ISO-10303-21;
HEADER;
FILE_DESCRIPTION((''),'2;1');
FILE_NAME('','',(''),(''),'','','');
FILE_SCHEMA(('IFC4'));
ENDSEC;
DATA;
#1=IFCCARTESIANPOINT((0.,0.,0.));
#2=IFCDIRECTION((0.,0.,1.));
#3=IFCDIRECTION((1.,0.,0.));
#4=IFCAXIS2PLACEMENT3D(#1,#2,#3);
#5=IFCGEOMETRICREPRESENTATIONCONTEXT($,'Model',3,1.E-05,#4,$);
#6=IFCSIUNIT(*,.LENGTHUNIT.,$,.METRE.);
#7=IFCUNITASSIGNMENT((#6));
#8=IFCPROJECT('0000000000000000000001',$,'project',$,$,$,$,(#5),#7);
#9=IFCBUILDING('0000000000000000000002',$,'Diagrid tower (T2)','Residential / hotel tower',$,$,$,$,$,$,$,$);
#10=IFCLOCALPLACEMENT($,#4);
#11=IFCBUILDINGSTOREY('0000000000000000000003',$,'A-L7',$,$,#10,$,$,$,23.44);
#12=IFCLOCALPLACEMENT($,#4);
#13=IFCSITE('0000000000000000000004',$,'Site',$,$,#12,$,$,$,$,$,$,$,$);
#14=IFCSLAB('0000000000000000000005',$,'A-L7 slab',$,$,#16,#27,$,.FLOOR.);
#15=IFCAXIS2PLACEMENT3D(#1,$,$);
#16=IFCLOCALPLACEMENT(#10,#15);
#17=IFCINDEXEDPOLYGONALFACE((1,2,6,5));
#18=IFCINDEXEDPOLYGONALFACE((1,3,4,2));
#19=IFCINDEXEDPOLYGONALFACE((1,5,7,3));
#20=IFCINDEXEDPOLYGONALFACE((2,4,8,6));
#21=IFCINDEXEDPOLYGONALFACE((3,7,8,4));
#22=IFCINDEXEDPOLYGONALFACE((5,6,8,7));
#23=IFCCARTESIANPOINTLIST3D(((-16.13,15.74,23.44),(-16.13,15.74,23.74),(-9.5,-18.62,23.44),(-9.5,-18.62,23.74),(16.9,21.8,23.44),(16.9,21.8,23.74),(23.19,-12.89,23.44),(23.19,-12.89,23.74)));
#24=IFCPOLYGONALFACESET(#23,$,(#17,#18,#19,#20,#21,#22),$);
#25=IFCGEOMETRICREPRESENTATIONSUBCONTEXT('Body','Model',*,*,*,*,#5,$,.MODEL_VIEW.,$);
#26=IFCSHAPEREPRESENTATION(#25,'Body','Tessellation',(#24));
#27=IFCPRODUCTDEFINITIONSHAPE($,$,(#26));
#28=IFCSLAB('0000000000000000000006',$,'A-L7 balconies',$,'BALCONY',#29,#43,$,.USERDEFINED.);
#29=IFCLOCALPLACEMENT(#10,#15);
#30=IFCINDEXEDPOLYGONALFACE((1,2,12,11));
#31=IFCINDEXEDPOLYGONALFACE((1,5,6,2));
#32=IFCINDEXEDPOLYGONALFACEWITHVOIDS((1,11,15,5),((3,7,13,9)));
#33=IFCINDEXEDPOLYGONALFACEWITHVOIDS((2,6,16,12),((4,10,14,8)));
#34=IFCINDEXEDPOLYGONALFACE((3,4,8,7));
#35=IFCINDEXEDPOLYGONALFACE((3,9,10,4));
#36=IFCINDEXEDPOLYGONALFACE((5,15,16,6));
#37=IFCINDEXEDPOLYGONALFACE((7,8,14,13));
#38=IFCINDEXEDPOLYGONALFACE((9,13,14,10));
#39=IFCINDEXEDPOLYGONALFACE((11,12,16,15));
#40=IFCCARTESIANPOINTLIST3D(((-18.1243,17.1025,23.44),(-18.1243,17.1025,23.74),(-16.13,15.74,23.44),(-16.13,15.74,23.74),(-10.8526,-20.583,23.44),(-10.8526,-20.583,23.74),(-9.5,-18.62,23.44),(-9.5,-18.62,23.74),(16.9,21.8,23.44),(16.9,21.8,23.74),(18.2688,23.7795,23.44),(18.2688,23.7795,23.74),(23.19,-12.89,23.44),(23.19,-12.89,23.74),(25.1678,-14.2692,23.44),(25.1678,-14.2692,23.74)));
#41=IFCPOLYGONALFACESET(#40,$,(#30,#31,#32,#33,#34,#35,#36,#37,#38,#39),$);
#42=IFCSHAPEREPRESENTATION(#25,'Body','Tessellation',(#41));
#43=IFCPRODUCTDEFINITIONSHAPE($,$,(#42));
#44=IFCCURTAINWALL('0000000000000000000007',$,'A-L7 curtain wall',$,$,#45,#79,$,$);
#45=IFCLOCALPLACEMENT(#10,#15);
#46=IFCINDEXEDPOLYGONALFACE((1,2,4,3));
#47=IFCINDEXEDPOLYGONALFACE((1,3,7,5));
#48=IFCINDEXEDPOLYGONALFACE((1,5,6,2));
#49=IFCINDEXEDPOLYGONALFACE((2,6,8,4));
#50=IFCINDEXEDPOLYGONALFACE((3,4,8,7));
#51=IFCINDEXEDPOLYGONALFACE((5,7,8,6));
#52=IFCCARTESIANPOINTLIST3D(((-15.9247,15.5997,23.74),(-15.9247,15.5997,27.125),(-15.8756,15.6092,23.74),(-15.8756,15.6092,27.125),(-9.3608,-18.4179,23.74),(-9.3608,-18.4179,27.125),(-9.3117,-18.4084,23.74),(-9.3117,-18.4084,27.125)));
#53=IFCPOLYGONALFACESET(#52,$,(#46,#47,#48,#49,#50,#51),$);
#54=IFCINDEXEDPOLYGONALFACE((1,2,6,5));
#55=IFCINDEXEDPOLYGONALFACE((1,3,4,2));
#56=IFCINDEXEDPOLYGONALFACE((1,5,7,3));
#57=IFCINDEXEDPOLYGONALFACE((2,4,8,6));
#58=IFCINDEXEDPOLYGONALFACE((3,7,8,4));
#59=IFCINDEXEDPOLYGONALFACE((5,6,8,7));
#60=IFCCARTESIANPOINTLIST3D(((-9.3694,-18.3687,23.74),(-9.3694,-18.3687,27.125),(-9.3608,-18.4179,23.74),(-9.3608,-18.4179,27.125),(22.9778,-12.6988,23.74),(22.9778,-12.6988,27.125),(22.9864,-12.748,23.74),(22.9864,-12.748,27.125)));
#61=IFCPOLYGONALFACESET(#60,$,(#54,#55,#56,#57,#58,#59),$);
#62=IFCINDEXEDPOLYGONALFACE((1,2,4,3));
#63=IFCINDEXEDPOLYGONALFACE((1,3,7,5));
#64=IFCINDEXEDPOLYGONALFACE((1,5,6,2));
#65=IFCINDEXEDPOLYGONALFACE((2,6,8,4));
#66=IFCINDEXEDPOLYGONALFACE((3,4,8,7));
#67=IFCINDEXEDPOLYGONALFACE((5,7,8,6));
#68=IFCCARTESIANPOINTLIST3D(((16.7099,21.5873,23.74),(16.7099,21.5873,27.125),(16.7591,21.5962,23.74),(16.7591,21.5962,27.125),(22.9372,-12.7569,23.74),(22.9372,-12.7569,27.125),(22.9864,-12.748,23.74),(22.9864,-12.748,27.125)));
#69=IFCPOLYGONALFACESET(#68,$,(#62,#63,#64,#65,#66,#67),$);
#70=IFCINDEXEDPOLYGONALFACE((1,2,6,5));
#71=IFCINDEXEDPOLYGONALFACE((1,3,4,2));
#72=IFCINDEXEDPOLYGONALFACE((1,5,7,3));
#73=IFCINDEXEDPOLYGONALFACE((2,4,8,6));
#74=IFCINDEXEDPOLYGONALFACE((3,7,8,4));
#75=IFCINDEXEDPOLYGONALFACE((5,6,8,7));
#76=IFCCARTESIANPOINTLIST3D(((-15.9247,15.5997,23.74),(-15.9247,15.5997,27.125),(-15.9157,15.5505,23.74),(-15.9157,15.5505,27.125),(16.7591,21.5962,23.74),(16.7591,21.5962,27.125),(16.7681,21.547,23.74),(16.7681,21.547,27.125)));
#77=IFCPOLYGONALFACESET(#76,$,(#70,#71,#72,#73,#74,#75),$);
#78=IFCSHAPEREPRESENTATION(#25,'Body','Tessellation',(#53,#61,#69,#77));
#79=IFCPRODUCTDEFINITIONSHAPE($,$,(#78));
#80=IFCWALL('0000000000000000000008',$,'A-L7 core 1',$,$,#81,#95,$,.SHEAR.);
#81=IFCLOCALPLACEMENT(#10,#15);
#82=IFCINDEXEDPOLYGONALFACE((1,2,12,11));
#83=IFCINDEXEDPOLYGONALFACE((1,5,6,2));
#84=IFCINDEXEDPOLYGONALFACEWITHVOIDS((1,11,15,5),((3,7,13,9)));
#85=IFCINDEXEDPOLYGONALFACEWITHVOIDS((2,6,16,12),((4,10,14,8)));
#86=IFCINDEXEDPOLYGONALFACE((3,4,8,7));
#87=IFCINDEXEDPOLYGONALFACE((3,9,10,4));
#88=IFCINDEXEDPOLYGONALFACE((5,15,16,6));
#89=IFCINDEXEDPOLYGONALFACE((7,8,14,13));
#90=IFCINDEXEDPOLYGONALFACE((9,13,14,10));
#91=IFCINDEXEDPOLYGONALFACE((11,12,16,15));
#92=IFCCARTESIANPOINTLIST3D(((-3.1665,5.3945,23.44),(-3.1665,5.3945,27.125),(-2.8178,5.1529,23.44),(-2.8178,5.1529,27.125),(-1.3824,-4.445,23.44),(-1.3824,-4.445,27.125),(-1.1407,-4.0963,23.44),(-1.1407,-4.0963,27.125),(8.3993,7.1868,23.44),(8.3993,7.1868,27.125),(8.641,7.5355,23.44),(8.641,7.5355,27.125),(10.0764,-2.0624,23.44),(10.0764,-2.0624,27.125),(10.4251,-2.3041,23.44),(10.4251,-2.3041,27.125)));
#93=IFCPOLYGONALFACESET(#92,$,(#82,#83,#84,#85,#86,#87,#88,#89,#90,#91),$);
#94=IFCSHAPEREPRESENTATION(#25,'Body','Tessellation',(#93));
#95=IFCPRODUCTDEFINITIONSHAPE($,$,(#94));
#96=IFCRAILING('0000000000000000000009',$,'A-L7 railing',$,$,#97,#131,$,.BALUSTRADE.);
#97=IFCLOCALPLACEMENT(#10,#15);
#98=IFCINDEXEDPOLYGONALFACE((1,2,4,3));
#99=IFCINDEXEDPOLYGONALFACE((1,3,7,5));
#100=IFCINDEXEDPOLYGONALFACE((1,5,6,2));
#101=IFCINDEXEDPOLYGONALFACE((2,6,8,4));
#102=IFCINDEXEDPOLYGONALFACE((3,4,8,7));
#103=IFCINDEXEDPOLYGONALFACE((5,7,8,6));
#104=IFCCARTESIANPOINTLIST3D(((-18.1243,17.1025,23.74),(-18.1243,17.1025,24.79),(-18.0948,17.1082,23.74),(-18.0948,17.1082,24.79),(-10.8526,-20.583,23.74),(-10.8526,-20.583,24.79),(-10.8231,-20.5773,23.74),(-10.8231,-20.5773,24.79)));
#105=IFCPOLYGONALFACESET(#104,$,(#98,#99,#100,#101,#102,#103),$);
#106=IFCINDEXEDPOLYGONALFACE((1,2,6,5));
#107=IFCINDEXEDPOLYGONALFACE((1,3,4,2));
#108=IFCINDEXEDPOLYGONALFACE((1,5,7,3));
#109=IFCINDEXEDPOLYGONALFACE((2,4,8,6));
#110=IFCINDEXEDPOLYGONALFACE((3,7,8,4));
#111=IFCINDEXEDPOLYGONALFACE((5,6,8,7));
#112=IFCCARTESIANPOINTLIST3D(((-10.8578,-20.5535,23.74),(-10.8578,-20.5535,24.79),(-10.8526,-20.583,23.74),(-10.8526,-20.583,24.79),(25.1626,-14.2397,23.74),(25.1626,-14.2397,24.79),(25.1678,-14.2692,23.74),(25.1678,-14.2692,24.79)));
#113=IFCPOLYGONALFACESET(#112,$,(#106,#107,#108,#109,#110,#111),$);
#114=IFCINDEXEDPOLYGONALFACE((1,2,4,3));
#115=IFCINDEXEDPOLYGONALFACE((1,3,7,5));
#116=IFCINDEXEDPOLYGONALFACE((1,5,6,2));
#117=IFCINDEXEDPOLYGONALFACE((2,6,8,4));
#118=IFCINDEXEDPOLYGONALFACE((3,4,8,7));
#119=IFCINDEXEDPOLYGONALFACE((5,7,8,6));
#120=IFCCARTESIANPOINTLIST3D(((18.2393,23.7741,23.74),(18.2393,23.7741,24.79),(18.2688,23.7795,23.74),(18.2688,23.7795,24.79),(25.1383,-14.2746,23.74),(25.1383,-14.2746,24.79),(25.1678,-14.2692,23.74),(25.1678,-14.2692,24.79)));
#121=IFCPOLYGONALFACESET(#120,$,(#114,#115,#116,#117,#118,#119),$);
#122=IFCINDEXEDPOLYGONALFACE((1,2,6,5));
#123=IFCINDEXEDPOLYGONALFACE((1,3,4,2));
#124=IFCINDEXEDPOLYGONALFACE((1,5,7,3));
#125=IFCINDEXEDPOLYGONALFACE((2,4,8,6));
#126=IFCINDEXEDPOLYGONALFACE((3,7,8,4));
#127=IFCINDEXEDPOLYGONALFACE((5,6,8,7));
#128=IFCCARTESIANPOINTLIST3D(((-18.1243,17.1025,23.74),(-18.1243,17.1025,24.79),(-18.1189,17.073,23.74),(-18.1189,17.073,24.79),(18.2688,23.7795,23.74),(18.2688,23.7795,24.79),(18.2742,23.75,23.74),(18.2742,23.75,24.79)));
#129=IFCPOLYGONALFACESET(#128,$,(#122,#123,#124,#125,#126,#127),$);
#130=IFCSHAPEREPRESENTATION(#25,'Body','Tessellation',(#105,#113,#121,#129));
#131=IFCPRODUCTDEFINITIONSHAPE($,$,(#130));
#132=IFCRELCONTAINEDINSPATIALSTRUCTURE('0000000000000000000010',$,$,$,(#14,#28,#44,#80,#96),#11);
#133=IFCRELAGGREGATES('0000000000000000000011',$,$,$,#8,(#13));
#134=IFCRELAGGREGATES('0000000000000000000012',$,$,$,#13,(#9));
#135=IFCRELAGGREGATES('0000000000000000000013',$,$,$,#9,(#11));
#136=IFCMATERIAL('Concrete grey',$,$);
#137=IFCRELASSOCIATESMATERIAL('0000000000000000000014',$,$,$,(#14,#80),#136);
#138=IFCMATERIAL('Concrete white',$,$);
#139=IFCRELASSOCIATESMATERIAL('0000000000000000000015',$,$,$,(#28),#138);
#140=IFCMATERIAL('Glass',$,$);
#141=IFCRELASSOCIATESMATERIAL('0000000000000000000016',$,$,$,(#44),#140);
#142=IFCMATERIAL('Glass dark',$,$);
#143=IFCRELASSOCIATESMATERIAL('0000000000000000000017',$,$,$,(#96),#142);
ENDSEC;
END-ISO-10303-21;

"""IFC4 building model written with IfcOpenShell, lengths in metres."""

from ifc_helpers import new_model, si_unit, frame, origin_with_axes, place, context, subcontext, project, spatial, polyline, outline, extrude, material, element, save


model = new_model("IFC4")

# Units and contexts
model_context = context("Model", 3, precision=1e-05, world=origin_with_axes())
body_context = subcontext(model_context, "Body", "Model", "MODEL_VIEW")
ifc_project = project(units=[si_unit("LENGTHUNIT", "METRE")], contexts=[model_context])

# Site, building, storey
site_placement = place(None, origin_with_axes())
site = spatial("IfcSite", under=ifc_project, at=site_placement, Name="Site")
building = spatial("IfcBuilding", under=site, Name="Diagrid tower (T2)", Description="Residential / hotel tower")
storey_placement = place(None, origin_with_axes())
storey = spatial("IfcBuildingStorey", under=building, at=storey_placement, Name="A-L7", Elevation=23.44)

# Slabs
ifc_material_1 = material(Name="Concrete grey")
slab_1_placement = place(storey_placement, origin_with_axes())
element("IfcSlab", 1, at=slab_1_placement, inside=storey, material=ifc_material_1, Name="A-L7 slab", PredefinedType="FLOOR", context=body_context, shape_type="SweptSolid", body=[
    extrude(outline(polyline([(-16.13, 15.74), (-9.5, -18.62), (23.19, -12.89), (16.9, 21.8), (-16.13, 15.74)])), frame((0.0, 0.0, 23.44), z_axis=(0.0, 0.0, 1.0), x_axis=(1.0, 0.0, 0.0)), (0.0, 0.0, 1.0), 0.3),
])
ifc_material_2 = material(Name="Concrete white")
slab_2_placement = place(storey_placement, origin_with_axes())
element("IfcSlab", 2, at=slab_2_placement, inside=storey, material=ifc_material_2, Name="A-L7 balconies", ObjectType="BALCONY", PredefinedType="USERDEFINED", context=body_context, shape_type="SweptSolid", body=[
    extrude(outline(polyline([(-18.1243, 17.1025), (-10.8526, -20.583), (25.1678, -14.2692), (18.2688, 23.7795), (-18.1243, 17.1025)]), holes=[polyline([(-16.13, 15.74), (-9.5, -18.62), (23.19, -12.89), (16.9, 21.8), (-16.13, 15.74)])]), frame((0.0, 0.0, 23.44), z_axis=(0.0, 0.0, 1.0), x_axis=(1.0, 0.0, 0.0)), (0.0, 0.0, 1.0), 0.3),
])

# Curtain wall
ifc_material_3 = material(Name="Glass")
curtain_wall_placement = place(storey_placement, origin_with_axes())
element("IfcCurtainWall", 3, at=curtain_wall_placement, inside=storey, material=ifc_material_3, Name="A-L7 curtain wall", context=body_context, shape_type="SweptSolid", body=[
    extrude(outline(polyline([(-15.9247, 15.5997), (-9.3608, -18.4179), (-9.3117, -18.4084), (-15.8756, 15.6092), (-15.9247, 15.5997)])), frame((0.0, 0.0, 23.74), z_axis=(0.0, 0.0, 1.0), x_axis=(1.0, 0.0, 0.0)), (0.0, 0.0, 1.0), 3.385),
    extrude(outline(polyline([(-9.3608, -18.4179), (22.9864, -12.748), (22.9778, -12.6988), (-9.3694, -18.3687), (-9.3608, -18.4179)])), frame((0.0, 0.0, 23.74), z_axis=(0.0, 0.0, 1.0), x_axis=(1.0, 0.0, 0.0)), (0.0, 0.0, 1.0), 3.385),
    extrude(outline(polyline([(22.9864, -12.748), (16.7591, 21.5962), (16.7099, 21.5873), (22.9372, -12.7569), (22.9864, -12.748)])), frame((0.0, 0.0, 23.74), z_axis=(0.0, 0.0, 1.0), x_axis=(1.0, 0.0, 0.0)), (0.0, 0.0, 1.0), 3.385),
    extrude(outline(polyline([(16.7591, 21.5962), (-15.9247, 15.5997), (-15.9157, 15.5505), (16.7681, 21.547), (16.7591, 21.5962)])), frame((0.0, 0.0, 23.74), z_axis=(0.0, 0.0, 1.0), x_axis=(1.0, 0.0, 0.0)), (0.0, 0.0, 1.0), 3.385),
])

# Wall
wall_placement = place(storey_placement, origin_with_axes())
element("IfcWall", 4, at=wall_placement, inside=storey, material=ifc_material_1, Name="A-L7 core 1", PredefinedType="SHEAR", context=body_context, shape_type="SweptSolid", body=[
    extrude(outline(polyline([(10.4251, -2.3041), (8.641, 7.5355), (-3.1665, 5.3945), (-1.3824, -4.445), (10.4251, -2.3041)]), holes=[polyline([(10.0764, -2.0624), (8.3993, 7.1868), (-2.8178, 5.1529), (-1.1407, -4.0963), (10.0764, -2.0624)])]), frame((0.0, 0.0, 23.44), z_axis=(0.0, 0.0, 1.0), x_axis=(1.0, 0.0, 0.0)), (0.0, 0.0, 1.0), 3.685),
])

# Railing
ifc_material_4 = material(Name="Glass dark")
railing_placement = place(storey_placement, origin_with_axes())
element("IfcRailing", 5, at=railing_placement, inside=storey, material=ifc_material_4, Name="A-L7 railing", PredefinedType="BALUSTRADE", context=body_context, shape_type="SweptSolid", body=[
    extrude(outline(polyline([(-18.1243, 17.1025), (-10.8526, -20.583), (-10.8231, -20.5773), (-18.0948, 17.1082), (-18.1243, 17.1025)])), frame((0.0, 0.0, 23.74), z_axis=(0.0, 0.0, 1.0), x_axis=(1.0, 0.0, 0.0)), (0.0, 0.0, 1.0), 1.05),
    extrude(outline(polyline([(-10.8526, -20.583), (25.1678, -14.2692), (25.1626, -14.2397), (-10.8578, -20.5535), (-10.8526, -20.583)])), frame((0.0, 0.0, 23.74), z_axis=(0.0, 0.0, 1.0), x_axis=(1.0, 0.0, 0.0)), (0.0, 0.0, 1.0), 1.05),
    extrude(outline(polyline([(25.1678, -14.2692), (18.2688, 23.7795), (18.2393, 23.7741), (25.1383, -14.2746), (25.1678, -14.2692)])), frame((0.0, 0.0, 23.74), z_axis=(0.0, 0.0, 1.0), x_axis=(1.0, 0.0, 0.0)), (0.0, 0.0, 1.0), 1.05),
    extrude(outline(polyline([(18.2688, 23.7795), (-18.1243, 17.1025), (-18.1189, 17.073), (18.2742, 23.75), (18.2688, 23.7795)])), frame((0.0, 0.0, 23.74), z_axis=(0.0, 0.0, 1.0), x_axis=(1.0, 0.0, 0.0)), (0.0, 0.0, 1.0), 1.05),
])

save(model, "model.ifc")
